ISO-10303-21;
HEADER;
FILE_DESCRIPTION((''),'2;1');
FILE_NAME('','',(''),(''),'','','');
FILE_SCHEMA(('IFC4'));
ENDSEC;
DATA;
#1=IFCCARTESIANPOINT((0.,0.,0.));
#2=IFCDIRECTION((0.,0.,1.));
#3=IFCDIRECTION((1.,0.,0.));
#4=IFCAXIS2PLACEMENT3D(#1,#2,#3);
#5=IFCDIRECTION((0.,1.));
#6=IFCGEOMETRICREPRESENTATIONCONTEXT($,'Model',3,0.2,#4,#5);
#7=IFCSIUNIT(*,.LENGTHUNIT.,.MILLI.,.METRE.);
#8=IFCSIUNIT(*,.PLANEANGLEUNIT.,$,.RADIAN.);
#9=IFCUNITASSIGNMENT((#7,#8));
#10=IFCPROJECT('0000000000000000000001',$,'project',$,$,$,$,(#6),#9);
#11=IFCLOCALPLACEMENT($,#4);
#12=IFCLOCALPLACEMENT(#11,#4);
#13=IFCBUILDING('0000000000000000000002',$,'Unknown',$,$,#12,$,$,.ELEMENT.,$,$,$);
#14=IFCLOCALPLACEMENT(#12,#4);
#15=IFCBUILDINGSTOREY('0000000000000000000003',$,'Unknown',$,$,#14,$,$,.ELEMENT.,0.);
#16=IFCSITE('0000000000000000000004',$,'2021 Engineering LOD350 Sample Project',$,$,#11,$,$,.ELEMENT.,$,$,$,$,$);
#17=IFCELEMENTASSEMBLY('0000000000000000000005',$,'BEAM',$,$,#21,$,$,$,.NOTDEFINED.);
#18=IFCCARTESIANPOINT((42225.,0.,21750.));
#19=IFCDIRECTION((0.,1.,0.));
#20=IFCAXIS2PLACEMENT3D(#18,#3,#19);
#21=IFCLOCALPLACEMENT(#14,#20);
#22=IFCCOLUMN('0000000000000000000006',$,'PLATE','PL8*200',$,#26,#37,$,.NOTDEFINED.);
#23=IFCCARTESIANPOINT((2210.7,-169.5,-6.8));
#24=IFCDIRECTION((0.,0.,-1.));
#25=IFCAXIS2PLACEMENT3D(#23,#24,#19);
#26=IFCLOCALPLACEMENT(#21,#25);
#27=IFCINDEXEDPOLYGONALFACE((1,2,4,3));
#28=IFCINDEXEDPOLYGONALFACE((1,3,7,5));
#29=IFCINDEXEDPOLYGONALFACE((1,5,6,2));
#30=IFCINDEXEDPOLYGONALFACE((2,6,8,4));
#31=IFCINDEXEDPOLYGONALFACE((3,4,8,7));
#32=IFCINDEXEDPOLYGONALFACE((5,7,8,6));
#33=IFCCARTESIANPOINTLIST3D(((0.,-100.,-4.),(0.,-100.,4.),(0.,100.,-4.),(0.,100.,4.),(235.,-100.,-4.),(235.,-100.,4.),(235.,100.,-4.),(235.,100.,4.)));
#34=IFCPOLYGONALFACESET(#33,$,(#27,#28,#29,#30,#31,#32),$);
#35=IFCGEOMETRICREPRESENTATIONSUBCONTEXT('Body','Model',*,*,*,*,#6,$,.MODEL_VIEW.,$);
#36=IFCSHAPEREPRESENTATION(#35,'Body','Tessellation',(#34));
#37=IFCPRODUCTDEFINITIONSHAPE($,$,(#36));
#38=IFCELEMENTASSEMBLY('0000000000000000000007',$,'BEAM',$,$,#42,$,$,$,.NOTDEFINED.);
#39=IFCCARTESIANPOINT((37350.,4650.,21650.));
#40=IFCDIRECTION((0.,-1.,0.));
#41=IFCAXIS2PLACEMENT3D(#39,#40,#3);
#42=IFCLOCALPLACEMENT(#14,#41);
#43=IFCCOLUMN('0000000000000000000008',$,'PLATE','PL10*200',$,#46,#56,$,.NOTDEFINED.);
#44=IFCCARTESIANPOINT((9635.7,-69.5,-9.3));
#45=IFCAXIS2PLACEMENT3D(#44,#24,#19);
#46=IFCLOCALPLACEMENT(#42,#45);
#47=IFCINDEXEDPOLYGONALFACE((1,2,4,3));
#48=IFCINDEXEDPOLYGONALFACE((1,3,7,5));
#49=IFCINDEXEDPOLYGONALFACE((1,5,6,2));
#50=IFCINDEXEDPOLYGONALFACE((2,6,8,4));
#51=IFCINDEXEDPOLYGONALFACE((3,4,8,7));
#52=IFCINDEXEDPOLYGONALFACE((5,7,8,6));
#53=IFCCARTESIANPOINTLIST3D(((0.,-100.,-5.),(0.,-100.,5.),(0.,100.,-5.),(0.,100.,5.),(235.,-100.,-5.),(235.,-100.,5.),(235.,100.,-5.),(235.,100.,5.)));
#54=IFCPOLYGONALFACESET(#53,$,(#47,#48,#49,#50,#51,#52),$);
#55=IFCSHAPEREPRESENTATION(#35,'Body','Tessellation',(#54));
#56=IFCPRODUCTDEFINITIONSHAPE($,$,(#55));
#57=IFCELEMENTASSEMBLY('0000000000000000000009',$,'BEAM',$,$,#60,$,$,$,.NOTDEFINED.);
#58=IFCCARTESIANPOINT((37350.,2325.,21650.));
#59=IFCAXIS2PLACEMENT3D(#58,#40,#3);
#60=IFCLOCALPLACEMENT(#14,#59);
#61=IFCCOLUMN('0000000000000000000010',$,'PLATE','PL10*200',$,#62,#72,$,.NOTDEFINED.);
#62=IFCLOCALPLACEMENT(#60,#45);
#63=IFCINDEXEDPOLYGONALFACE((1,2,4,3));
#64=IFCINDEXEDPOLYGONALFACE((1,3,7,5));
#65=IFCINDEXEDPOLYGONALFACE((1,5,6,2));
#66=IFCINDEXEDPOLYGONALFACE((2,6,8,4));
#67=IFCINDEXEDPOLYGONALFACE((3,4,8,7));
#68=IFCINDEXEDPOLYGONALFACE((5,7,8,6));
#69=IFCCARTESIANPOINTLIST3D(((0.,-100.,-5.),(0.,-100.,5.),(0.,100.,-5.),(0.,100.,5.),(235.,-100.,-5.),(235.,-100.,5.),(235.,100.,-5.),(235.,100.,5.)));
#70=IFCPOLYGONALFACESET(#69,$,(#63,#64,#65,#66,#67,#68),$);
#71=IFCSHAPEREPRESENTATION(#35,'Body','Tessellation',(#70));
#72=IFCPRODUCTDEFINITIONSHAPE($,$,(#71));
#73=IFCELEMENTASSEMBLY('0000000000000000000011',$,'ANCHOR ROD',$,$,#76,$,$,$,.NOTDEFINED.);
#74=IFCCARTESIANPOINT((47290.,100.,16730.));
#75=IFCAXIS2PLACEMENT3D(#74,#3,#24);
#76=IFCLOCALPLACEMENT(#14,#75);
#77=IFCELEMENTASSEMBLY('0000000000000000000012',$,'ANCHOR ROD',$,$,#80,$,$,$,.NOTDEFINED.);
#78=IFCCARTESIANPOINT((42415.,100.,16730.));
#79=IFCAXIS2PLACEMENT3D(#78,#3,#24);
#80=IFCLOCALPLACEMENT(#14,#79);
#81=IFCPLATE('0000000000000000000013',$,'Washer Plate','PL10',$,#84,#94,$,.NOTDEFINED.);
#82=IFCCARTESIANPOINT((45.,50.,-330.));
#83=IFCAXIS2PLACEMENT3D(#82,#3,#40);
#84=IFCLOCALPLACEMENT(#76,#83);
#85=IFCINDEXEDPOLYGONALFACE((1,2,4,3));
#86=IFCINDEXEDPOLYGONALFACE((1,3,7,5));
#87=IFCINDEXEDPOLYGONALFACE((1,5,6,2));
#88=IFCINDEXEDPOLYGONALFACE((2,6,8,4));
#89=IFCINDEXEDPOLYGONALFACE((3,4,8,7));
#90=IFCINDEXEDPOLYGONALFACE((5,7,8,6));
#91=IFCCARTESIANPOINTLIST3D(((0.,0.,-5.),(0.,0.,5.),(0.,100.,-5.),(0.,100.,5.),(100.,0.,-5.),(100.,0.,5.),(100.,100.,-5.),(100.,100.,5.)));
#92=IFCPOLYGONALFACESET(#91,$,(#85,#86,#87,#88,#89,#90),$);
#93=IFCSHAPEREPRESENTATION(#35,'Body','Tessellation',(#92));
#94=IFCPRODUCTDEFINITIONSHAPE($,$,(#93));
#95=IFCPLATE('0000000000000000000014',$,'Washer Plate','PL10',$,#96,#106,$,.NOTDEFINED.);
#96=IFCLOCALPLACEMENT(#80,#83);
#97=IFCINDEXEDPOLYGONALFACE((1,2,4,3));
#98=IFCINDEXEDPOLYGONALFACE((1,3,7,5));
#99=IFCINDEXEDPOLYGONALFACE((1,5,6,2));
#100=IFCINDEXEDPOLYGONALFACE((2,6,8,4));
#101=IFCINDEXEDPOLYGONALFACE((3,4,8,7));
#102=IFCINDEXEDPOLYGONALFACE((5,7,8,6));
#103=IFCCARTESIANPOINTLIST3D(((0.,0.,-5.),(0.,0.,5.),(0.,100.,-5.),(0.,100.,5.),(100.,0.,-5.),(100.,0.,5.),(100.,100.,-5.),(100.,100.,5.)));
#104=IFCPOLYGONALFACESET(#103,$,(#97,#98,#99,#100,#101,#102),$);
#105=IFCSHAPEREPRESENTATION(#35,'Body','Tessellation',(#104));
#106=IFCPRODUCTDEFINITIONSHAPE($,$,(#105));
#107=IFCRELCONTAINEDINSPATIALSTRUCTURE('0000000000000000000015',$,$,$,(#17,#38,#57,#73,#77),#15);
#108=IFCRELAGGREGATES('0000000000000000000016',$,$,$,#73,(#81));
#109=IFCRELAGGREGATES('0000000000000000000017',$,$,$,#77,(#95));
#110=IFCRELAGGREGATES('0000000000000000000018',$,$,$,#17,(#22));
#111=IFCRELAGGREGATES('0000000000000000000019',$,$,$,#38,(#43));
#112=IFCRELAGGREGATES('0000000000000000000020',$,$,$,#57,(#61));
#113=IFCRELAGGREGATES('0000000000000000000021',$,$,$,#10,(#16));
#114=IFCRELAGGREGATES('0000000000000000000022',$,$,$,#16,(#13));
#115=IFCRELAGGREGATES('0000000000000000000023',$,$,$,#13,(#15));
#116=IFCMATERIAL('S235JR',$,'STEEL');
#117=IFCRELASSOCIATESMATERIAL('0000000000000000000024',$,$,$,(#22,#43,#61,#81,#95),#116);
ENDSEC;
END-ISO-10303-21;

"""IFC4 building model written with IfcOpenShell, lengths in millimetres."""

from ifc_helpers import new_model, si_unit, direction, frame, origin_with_axes, place, context, subcontext, project, spatial, line, indexed_curve, outline, extrude, material, element, aggregate, save


model = new_model("IFC4")

# Units and contexts
model_context = context("Model", 3, precision=0.2, world=origin_with_axes(), true_north=direction((0.0, 1.0)))
body_context = subcontext(model_context, "Body", "Model", "MODEL_VIEW")
ifc_project = project(units=[si_unit("LENGTHUNIT", "METRE", prefix="MILLI"), si_unit("PLANEANGLEUNIT", "RADIAN")], contexts=[model_context])

# Site, building, storey
site_placement = place(None, origin_with_axes())
site = spatial("IfcSite", under=ifc_project, at=site_placement, Name="2021 Engineering LOD350 Sample Project", CompositionType="ELEMENT")
building_placement = place(site_placement, origin_with_axes())
building = spatial("IfcBuilding", under=site, at=building_placement, Name="Unknown", CompositionType="ELEMENT")
storey_placement = place(building_placement, origin_with_axes())
storey = spatial("IfcBuildingStorey", under=building, at=storey_placement, Name="Unknown", CompositionType="ELEMENT", Elevation=0.0)

# Element assembly, column
assembly_1_placement = place(storey_placement, frame((42225.0, 0.0, 21750.0), z_axis=(1.0, 0.0, 0.0), x_axis=(0.0, 1.0, 0.0)))
assembly_1 = element("IfcElementAssembly", 1, at=assembly_1_placement, inside=storey, Name="BEAM", PredefinedType="NOTDEFINED")
ifc_material_1 = material(Name="S235JR", Category="STEEL")
column_1_placement = place(assembly_1_placement, frame((2210.7, -169.5, -6.8), z_axis=(0.0, 0.0, -1.0), x_axis=(0.0, 1.0, 0.0)))
column_1 = element("IfcColumn", 2, at=column_1_placement, material=ifc_material_1, Name="PLATE", Description="PL8*200", PredefinedType="NOTDEFINED", context=body_context, shape_type="SolidModel", body=[
    extrude(outline(indexed_curve([(-4.0, -100.0), (4.0, -100.0), (4.0, 100.0), (-4.0, 100.0)], segments=[line(1, 2, 3, 4, 1)])), frame((0.0, 0.0, 0.0), z_axis=(-1.0, 0.0, 0.0), x_axis=(0.0, 0.0, 1.0)), (0.0, 0.0, -1.0), 235.0),
])

# Element assemblies, columns
assembly_2_placement = place(storey_placement, frame((37350.0, 4650.0, 21650.0), z_axis=(0.0, -1.0, 0.0), x_axis=(1.0, 0.0, 0.0)))
assembly_2 = element("IfcElementAssembly", 3, at=assembly_2_placement, inside=storey, Name="BEAM", PredefinedType="NOTDEFINED")
column_2_placement = place(assembly_2_placement, frame((9635.7, -69.5, -9.3), z_axis=(0.0, 0.0, -1.0), x_axis=(0.0, 1.0, 0.0)))
column_2 = element("IfcColumn", 4, at=column_2_placement, material=ifc_material_1, Name="PLATE", Description="PL10*200", PredefinedType="NOTDEFINED", context=body_context, shape_type="SolidModel", body=[
    extrude(outline(indexed_curve([(-5.0, -100.0), (5.0, -100.0), (5.0, 100.0), (-5.0, 100.0)], segments=[line(1, 2, 3, 4, 1)])), frame((0.0, 0.0, 0.0), z_axis=(-1.0, 0.0, 0.0), x_axis=(0.0, 0.0, 1.0)), (0.0, 0.0, -1.0), 235.0),
])
assembly_3_placement = place(storey_placement, frame((37350.0, 2325.0, 21650.0), z_axis=(0.0, -1.0, 0.0), x_axis=(1.0, 0.0, 0.0)))
assembly_3 = element("IfcElementAssembly", 5, at=assembly_3_placement, inside=storey, Name="BEAM", PredefinedType="NOTDEFINED")
column_3_placement = place(assembly_3_placement, frame((9635.7, -69.5, -9.3), z_axis=(0.0, 0.0, -1.0), x_axis=(0.0, 1.0, 0.0)))
column_3 = element("IfcColumn", 6, at=column_3_placement, material=ifc_material_1, Name="PLATE", Description="PL10*200", PredefinedType="NOTDEFINED", context=body_context, shape_type="SolidModel", body=[
    extrude(outline(indexed_curve([(-5.0, -100.0), (5.0, -100.0), (5.0, 100.0), (-5.0, 100.0)], segments=[line(1, 2, 3, 4, 1)])), frame((0.0, 0.0, 0.0), z_axis=(-1.0, 0.0, 0.0), x_axis=(0.0, 0.0, 1.0)), (0.0, 0.0, -1.0), 235.0),
])

# Element assemblies
assembly_4_placement = place(storey_placement, frame((47290.0, 100.0, 16730.0), z_axis=(1.0, 0.0, 0.0), x_axis=(0.0, 0.0, -1.0)))
assembly_4 = element("IfcElementAssembly", 7, at=assembly_4_placement, inside=storey, Name="ANCHOR ROD", PredefinedType="NOTDEFINED")
assembly_5_placement = place(storey_placement, frame((42415.0, 100.0, 16730.0), z_axis=(1.0, 0.0, 0.0), x_axis=(0.0, 0.0, -1.0)))
assembly_5 = element("IfcElementAssembly", 8, at=assembly_5_placement, inside=storey, Name="ANCHOR ROD", PredefinedType="NOTDEFINED")

# Plates
plate_1_placement = place(assembly_4_placement, frame((45.0, 50.0, -330.0), z_axis=(1.0, 0.0, 0.0), x_axis=(0.0, -1.0, 0.0)))
plate_1 = element("IfcPlate", 9, at=plate_1_placement, material=ifc_material_1, Name="Washer Plate", Description="PL10", PredefinedType="NOTDEFINED", context=body_context, shape_type="SolidModel", body=[
    extrude(outline(indexed_curve([(0.0, 0.0), (100.0, 0.0), (100.0, 100.0), (0.0, 100.0)], segments=[line(1, 2, 3, 4, 1)])), frame((0.0, 0.0, 5.0), z_axis=(0.0, 0.0, 1.0), x_axis=(1.0, 0.0, 0.0)), (0.0, 0.0, -1.0), 10.0),
])
aggregate(assembly_4, [plate_1])
plate_2_placement = place(assembly_5_placement, frame((45.0, 50.0, -330.0), z_axis=(1.0, 0.0, 0.0), x_axis=(0.0, -1.0, 0.0)))
plate_2 = element("IfcPlate", 10, at=plate_2_placement, material=ifc_material_1, Name="Washer Plate", Description="PL10", PredefinedType="NOTDEFINED", context=body_context, shape_type="SolidModel", body=[
    extrude(outline(indexed_curve([(0.0, 0.0), (100.0, 0.0), (100.0, 100.0), (0.0, 100.0)], segments=[line(1, 2, 3, 4, 1)])), frame((0.0, 0.0, 5.0), z_axis=(0.0, 0.0, 1.0), x_axis=(1.0, 0.0, 0.0)), (0.0, 0.0, -1.0), 10.0),
])
aggregate(assembly_5, [plate_2])

aggregate(assembly_1, [column_1])
aggregate(assembly_2, [column_2])
aggregate(assembly_3, [column_3])

save(model, "model.ifc")
